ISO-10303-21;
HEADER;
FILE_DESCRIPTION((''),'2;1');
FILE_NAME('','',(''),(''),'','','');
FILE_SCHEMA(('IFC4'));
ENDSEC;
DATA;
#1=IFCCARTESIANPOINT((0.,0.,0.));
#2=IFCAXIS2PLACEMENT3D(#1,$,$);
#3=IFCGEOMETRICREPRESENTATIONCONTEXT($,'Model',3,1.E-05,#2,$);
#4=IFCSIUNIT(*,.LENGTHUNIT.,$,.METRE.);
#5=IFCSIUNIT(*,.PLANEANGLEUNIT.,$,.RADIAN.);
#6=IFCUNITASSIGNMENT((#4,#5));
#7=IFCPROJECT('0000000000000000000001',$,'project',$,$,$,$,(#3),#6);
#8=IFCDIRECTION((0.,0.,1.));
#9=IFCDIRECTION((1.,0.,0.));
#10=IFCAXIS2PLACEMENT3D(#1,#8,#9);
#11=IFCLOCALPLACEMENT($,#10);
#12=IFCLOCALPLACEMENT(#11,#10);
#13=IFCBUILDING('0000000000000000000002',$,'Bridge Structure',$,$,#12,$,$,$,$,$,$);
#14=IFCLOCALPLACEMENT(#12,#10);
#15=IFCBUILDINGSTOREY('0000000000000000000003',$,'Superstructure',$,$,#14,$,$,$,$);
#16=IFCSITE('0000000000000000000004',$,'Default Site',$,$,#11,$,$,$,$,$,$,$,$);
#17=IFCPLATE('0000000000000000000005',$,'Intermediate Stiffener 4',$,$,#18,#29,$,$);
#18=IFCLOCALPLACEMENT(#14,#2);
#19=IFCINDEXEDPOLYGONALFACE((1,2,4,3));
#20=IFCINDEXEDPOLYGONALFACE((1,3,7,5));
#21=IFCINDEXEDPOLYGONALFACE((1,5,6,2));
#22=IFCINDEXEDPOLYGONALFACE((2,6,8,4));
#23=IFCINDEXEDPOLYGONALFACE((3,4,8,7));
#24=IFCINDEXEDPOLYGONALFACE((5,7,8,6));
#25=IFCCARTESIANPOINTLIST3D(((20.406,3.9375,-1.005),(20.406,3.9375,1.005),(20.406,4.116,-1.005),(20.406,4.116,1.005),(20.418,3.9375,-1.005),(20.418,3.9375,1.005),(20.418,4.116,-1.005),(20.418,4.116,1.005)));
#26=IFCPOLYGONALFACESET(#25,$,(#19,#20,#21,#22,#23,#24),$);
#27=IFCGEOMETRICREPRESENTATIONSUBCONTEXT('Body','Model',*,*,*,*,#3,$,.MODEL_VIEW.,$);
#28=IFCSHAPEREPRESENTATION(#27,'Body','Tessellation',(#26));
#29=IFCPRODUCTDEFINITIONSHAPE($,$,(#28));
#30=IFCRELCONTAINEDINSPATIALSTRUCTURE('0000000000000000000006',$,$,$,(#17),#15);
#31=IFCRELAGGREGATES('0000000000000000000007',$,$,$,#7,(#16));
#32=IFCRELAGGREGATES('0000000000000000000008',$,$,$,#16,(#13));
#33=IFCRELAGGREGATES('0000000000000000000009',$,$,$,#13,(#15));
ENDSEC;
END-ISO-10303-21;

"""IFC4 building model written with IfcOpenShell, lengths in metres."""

from ifc_helpers import new_model, si_unit, frame, origin, origin_with_axes, origin_2d_with_axis, place, context, subcontext, project, spatial, rectangle, extrude, element, save


model = new_model("IFC4")

# Units and contexts
model_context = context("Model", 3, precision=1e-05, world=origin())
body_context = subcontext(model_context, "Body", "Model", "MODEL_VIEW")
ifc_project = project(units=[si_unit("LENGTHUNIT", "METRE"), si_unit("PLANEANGLEUNIT", "RADIAN")], contexts=[model_context])

# Site, building, storey
site_placement = place(None, origin_with_axes())
site = spatial("IfcSite", under=ifc_project, at=site_placement, Name="Default Site")
building_placement = place(site_placement, origin_with_axes())
building = spatial("IfcBuilding", under=site, at=building_placement, Name="Bridge Structure")
storey_placement = place(building_placement, origin_with_axes())
storey = spatial("IfcBuildingStorey", under=building, at=storey_placement, Name="Superstructure")

# Plate
for number, where, z_axis, x_axis, name in (
    (1, (20.412, 4.0267, -1.005), (0.0, 0.0, 1.0), (1.0, 0.0, 0.0), "Intermediate Stiffener 4"),
):
    element("IfcPlate", number, at=place(storey_placement, frame(where, z_axis=z_axis, x_axis=x_axis)), inside=storey, Name=name, context=body_context, shape_type="SweptSolid", body=[
        extrude(rectangle(XDim=0.012, YDim=0.1785, at=origin_2d_with_axis()), origin_with_axes(), (0.0, 0.0, 1.0), 2.01),
    ])

save(model, "model.ifc")
